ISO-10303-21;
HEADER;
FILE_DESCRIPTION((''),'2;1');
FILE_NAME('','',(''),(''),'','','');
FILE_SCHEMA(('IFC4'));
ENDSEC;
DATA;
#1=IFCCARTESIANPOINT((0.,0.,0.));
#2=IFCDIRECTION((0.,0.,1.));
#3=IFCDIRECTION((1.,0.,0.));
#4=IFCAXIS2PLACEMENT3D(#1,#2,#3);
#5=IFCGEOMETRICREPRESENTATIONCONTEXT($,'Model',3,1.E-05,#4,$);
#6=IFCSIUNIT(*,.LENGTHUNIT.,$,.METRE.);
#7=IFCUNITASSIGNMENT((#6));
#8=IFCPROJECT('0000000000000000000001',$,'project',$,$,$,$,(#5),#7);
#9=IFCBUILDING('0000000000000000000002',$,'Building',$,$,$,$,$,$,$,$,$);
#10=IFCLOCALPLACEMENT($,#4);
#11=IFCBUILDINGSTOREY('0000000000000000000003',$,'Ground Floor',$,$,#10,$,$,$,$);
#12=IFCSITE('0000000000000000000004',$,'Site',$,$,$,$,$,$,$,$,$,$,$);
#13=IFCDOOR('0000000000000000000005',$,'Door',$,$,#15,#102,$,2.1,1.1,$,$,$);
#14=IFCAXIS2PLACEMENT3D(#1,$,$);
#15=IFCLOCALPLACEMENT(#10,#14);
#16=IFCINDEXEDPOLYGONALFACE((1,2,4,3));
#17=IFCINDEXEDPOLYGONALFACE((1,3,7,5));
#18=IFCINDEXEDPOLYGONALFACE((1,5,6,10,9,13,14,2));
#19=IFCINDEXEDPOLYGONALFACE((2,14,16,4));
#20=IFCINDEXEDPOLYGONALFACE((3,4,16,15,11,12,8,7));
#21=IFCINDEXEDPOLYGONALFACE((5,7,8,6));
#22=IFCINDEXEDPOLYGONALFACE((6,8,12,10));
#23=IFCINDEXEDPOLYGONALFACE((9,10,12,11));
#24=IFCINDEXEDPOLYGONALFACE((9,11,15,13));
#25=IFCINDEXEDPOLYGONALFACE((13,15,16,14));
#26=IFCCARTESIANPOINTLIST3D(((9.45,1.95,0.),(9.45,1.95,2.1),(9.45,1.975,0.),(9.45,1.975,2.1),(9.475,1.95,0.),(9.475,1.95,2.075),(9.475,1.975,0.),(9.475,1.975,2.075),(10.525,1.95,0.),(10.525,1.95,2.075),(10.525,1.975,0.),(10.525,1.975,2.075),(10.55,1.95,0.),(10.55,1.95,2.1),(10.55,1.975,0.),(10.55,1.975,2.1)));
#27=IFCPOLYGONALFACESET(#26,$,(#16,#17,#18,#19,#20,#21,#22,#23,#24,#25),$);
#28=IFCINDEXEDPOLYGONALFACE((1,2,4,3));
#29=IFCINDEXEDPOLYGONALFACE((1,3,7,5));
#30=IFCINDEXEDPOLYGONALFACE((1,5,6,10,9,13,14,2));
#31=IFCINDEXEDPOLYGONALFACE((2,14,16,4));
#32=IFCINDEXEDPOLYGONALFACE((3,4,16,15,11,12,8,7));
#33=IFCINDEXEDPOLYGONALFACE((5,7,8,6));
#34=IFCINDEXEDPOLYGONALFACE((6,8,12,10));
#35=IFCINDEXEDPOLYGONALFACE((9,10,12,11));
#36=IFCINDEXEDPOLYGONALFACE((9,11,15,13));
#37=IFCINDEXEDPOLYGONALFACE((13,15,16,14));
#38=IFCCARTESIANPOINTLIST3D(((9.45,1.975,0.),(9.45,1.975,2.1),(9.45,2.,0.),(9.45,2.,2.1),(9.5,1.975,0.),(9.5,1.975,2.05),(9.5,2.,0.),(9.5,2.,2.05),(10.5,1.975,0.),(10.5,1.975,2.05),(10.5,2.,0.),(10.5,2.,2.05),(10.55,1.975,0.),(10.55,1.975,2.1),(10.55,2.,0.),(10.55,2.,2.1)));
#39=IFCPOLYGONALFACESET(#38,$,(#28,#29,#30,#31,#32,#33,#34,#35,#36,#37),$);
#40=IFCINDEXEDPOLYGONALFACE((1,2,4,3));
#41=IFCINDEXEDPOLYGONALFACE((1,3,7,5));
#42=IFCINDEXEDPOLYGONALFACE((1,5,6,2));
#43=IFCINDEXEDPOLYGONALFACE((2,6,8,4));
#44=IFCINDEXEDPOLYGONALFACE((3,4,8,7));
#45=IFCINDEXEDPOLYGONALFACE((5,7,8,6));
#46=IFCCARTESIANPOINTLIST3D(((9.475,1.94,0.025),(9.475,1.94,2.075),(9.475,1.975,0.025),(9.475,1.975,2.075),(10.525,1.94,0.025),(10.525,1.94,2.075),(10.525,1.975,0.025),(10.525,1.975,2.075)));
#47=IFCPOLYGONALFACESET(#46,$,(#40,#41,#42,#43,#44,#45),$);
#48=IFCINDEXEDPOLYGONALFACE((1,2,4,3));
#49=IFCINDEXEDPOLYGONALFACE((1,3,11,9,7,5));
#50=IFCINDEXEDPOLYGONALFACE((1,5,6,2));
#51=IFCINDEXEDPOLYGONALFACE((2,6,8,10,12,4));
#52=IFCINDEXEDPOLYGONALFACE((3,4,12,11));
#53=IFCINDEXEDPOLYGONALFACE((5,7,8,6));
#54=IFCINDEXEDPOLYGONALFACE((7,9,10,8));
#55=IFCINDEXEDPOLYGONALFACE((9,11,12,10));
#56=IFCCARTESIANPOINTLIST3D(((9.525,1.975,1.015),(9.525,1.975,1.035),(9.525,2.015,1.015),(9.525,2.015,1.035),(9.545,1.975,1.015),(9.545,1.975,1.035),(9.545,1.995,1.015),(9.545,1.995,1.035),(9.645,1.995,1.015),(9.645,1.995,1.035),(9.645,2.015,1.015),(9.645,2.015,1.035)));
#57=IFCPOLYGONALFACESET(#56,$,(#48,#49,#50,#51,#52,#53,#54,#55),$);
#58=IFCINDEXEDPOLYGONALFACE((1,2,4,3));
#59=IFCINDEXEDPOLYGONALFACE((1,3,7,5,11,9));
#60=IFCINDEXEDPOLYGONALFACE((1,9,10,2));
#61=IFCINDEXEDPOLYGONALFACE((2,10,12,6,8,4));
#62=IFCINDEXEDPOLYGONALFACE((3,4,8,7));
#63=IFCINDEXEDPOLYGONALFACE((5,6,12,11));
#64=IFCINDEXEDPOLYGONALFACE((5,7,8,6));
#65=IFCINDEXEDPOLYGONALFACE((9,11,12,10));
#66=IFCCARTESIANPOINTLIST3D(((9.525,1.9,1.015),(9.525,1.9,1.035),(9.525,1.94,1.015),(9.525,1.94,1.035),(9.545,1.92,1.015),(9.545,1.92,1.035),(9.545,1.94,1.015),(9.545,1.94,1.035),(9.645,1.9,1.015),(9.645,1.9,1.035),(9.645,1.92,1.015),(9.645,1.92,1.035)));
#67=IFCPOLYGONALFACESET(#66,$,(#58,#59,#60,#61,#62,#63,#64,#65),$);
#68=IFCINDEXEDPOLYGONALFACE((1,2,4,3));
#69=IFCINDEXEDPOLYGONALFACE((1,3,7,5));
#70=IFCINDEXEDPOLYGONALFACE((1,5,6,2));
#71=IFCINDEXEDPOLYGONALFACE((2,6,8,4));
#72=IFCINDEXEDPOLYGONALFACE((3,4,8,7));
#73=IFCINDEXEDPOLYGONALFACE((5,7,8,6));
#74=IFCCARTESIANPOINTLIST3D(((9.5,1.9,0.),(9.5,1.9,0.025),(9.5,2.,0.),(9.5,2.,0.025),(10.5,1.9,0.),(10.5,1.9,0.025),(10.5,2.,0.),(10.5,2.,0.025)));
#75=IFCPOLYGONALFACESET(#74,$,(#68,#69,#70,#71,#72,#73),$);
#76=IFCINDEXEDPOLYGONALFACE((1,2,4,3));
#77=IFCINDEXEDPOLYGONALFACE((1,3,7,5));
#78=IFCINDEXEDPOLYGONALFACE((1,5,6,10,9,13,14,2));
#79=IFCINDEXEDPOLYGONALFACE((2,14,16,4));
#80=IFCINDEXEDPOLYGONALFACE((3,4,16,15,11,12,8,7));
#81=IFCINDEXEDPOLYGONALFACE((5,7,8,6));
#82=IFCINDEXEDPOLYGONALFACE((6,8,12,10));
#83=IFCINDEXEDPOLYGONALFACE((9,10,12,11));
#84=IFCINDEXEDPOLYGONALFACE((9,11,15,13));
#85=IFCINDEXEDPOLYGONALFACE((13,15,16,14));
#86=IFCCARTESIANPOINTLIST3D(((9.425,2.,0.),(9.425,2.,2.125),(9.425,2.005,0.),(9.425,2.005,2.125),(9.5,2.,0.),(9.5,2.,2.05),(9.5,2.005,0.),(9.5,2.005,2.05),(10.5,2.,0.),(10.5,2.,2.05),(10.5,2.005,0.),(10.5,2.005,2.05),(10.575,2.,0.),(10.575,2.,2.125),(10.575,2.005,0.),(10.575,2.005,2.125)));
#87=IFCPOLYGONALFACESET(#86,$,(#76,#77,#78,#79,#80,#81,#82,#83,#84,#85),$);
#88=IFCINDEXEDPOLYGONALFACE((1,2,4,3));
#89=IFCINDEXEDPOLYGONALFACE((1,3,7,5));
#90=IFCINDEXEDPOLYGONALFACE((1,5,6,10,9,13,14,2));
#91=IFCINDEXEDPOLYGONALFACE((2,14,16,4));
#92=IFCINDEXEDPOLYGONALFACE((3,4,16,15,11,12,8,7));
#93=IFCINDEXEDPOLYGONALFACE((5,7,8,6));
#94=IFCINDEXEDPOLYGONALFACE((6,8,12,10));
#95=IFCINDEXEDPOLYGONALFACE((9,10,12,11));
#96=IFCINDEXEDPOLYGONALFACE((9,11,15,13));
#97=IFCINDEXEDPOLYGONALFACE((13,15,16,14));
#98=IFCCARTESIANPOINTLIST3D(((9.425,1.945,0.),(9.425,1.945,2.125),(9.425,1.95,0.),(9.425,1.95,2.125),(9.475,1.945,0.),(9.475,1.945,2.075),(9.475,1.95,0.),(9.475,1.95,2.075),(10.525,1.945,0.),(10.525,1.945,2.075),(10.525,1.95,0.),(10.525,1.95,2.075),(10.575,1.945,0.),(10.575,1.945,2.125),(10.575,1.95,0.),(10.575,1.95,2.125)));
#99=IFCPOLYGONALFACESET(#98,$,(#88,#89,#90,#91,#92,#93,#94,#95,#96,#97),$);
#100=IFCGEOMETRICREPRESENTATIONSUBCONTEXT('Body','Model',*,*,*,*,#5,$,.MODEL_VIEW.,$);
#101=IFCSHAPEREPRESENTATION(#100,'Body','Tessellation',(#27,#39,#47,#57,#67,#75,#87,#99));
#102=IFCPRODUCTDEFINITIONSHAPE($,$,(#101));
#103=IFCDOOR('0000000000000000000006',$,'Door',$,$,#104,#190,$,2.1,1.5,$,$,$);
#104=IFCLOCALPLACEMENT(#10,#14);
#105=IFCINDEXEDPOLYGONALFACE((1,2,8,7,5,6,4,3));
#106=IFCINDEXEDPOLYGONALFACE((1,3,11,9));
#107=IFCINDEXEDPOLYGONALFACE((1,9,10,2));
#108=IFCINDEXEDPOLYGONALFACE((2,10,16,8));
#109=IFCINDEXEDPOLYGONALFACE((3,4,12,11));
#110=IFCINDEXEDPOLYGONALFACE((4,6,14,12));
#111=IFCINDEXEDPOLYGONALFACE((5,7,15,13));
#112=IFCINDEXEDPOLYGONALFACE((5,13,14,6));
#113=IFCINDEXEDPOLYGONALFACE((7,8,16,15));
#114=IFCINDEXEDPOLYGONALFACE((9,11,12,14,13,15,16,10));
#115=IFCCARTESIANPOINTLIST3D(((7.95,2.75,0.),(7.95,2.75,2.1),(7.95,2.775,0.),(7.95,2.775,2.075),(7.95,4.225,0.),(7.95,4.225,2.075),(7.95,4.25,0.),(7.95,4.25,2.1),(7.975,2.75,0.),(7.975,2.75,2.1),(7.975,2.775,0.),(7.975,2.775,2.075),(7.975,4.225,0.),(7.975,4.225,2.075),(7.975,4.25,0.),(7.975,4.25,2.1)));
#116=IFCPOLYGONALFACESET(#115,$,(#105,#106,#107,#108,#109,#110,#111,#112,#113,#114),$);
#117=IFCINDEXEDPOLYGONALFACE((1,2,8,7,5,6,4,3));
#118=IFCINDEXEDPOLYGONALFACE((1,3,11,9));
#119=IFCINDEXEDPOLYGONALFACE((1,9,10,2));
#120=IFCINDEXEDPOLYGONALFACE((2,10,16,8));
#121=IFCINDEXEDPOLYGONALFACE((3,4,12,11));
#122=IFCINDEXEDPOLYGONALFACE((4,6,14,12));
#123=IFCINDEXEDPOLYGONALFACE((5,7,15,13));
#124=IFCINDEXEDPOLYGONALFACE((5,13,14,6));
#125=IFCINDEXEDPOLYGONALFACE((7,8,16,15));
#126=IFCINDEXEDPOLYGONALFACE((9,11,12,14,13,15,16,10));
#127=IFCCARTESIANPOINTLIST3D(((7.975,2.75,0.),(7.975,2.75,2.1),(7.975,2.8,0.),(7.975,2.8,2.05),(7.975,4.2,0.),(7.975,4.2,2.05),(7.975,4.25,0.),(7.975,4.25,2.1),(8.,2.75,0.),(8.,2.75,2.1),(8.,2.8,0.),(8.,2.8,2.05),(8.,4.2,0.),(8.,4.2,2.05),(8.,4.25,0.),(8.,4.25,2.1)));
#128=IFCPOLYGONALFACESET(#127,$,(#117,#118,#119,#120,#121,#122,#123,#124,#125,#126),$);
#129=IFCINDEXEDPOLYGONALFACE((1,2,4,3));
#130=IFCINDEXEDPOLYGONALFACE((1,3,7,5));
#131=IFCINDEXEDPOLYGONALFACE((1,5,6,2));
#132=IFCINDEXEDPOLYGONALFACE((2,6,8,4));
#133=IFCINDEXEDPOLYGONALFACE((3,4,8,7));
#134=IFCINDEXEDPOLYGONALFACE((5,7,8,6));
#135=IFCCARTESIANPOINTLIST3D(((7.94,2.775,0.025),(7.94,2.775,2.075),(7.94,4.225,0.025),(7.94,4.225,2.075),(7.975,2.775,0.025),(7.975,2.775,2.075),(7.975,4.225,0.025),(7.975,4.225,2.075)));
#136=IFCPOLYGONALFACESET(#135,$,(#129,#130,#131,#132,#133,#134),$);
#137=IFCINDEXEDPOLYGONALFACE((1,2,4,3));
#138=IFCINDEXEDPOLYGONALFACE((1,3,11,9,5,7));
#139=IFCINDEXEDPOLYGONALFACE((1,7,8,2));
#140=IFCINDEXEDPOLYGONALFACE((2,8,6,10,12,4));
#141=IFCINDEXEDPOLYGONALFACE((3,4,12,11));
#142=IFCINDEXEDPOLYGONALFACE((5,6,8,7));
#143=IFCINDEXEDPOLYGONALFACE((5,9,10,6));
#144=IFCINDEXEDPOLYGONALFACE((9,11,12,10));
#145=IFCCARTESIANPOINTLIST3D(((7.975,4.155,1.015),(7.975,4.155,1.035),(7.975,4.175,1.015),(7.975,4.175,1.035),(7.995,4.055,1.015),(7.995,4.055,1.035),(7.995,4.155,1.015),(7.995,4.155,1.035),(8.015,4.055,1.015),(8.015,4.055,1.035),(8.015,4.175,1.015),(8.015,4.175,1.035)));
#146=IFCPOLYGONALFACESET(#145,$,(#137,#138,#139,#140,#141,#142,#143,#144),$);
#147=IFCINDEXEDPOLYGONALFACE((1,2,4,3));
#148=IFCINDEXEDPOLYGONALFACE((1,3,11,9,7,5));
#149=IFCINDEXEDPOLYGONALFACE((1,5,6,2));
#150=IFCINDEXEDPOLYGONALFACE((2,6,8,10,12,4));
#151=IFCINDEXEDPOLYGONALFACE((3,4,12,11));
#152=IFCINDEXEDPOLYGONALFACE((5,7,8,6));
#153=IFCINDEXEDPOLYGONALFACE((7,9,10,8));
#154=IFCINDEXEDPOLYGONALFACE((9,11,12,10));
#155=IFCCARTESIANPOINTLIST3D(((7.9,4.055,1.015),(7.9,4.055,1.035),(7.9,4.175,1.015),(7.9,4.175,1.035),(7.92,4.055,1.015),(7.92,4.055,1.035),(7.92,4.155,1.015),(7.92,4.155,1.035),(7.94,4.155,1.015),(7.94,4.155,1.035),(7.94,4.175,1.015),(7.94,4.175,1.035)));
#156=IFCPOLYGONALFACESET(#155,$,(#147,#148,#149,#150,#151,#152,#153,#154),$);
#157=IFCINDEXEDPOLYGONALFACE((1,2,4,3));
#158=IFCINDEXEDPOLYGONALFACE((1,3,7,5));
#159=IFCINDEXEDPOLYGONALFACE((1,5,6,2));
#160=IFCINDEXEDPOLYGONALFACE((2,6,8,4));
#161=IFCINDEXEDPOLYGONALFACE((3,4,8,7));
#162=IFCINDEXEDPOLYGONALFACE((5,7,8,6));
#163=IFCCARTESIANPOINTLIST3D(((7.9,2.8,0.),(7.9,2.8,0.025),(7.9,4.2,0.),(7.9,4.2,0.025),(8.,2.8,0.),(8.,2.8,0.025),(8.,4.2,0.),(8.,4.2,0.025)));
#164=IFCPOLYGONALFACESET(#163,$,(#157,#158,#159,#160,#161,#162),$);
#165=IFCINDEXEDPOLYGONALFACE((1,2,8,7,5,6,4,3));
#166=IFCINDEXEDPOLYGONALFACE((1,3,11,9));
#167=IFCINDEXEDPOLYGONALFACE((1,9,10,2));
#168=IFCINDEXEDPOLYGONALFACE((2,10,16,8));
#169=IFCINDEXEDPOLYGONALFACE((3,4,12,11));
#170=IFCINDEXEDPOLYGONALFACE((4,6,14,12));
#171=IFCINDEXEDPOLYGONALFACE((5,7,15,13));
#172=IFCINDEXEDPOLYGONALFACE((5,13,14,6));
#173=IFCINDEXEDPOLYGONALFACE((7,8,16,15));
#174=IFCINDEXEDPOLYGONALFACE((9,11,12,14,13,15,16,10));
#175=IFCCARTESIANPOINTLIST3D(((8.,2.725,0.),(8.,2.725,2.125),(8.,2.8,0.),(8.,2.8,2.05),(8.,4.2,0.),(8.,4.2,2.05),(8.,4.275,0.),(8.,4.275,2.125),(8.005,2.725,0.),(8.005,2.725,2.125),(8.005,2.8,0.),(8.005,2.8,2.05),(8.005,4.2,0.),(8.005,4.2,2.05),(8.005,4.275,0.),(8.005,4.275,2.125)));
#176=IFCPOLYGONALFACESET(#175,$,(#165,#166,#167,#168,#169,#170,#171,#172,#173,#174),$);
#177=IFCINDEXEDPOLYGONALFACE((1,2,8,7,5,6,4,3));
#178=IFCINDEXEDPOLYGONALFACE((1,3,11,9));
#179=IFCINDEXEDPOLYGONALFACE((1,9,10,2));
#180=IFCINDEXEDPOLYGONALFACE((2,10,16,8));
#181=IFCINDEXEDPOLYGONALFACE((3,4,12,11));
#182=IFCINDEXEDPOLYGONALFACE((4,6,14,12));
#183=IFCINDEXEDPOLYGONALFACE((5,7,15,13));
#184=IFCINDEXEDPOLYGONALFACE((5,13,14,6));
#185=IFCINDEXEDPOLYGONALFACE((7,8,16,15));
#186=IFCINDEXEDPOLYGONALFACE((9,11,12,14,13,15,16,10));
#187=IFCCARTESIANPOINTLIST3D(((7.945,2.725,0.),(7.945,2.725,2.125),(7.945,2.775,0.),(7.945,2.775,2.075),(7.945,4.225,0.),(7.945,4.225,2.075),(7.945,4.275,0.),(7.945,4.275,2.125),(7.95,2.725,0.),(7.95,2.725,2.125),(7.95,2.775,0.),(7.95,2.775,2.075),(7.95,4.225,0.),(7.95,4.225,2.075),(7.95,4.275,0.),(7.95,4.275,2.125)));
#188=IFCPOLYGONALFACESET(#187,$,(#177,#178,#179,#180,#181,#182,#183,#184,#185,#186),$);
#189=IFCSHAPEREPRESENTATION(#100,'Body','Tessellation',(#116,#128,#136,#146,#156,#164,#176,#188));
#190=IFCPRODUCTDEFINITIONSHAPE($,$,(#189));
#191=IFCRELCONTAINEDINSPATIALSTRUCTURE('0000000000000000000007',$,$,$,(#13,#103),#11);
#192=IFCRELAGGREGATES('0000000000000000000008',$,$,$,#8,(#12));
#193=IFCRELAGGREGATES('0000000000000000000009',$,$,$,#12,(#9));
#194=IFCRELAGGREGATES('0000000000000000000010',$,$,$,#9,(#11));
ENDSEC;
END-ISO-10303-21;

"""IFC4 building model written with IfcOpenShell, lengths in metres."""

from ifc_helpers import new_model, si_unit, frame, origin_with_axes, place, context, subcontext, project, spatial, line, indexed_curve, outline, extrude, element, save


model = new_model("IFC4")

# Units and contexts
model_context = context("Model", 3, precision=1e-05, world=origin_with_axes())
body_context = subcontext(model_context, "Body", "Model", "MODEL_VIEW")
ifc_project = project(units=[si_unit("LENGTHUNIT", "METRE")], contexts=[model_context])

# Site, building, storey
site = spatial("IfcSite", under=ifc_project, Name="Site")
building = spatial("IfcBuilding", under=site, Name="Building")
storey_placement = place(None, origin_with_axes())
storey = spatial("IfcBuildingStorey", under=building, at=storey_placement, Name="Ground Floor")

# Doors
door_1_placement = place(storey_placement, frame((10.55, 2.0, 0.0), z_axis=(0.0, 0.0, 1.0), x_axis=(-1.0, 0.0, 0.0)))
element("IfcDoor", 1, at=door_1_placement, inside=storey, Name="Door", OverallHeight=2.1, OverallWidth=1.1, context=body_context, shape_type="SweptSolid", body=[
    extrude(outline(indexed_curve([(0.0, 0.0), (0.0, 2.1), (1.1, 2.1), (1.1, 0.0), (1.075, 0.0), (1.075, 2.075), (0.025, 2.075), (0.025, 0.0)], segments=[line(1, 2, 3, 4, 5, 6, 7, 8, 1)])), frame((0.0, 0.025, 0.0), z_axis=(0.0, -1.0, 0.0), x_axis=(1.0, 0.0, 0.0)), (0.0, 0.0, -1.0), 0.025),
    extrude(outline(indexed_curve([(0.0, 0.0), (0.0, 2.1), (1.1, 2.1), (1.1, 0.0), (1.05, 0.0), (1.05, 2.05), (0.05, 2.05), (0.05, 0.0)], segments=[line(1, 2, 3, 4, 5, 6, 7, 8, 1)])), frame((0.0, 0.0, 0.0), z_axis=(0.0, -1.0, 0.0), x_axis=(1.0, 0.0, 0.0)), (0.0, 0.0, -1.0), 0.025),
    extrude(outline(indexed_curve([(0.0, 0.0), (1.05, 0.0), (1.05, 0.035), (0.0, 0.035)], segments=[line(1, 2, 3, 4, 1)])), frame((0.025, 0.025, 0.025), z_axis=(0.0, 0.0, 1.0), x_axis=(1.0, 0.0, 0.0)), (0.0, 0.0, 1.0), 2.05),
    extrude(outline(indexed_curve([(0.0, 0.0), (0.0, -0.04), (-0.12, -0.04), (-0.12, -0.02), (-0.02, -0.02), (-0.02, 0.0)], segments=[line(1, 2, 3, 4, 5, 6, 1)])), frame((1.025, 0.025, 1.015), z_axis=(0.0, 0.0, 1.0), x_axis=(1.0, 0.0, 0.0)), (0.0, 0.0, 1.0), 0.02),
    extrude(outline(indexed_curve([(0.0, 0.0), (0.0, 0.04), (-0.12, 0.04), (-0.12, 0.02), (-0.02, 0.02), (-0.02, 0.0)], segments=[line(1, 2, 3, 4, 5, 6, 1)])), frame((1.025, 0.06, 1.015), z_axis=(0.0, 0.0, 1.0), x_axis=(1.0, 0.0, 0.0)), (0.0, 0.0, 1.0), 0.02),
    extrude(outline(indexed_curve([(0.0, 0.0), (1.0, 0.0), (1.0, 0.1), (0.0, 0.1)], segments=[line(1, 2, 3, 4, 1)])), frame((0.05, 0.0, 0.0), z_axis=(0.0, 0.0, 1.0), x_axis=(1.0, 0.0, 0.0)), (0.0, 0.0, 1.0), 0.025),
    extrude(outline(indexed_curve([(0.0, 0.0), (0.0, 2.125), (1.15, 2.125), (1.15, 0.0), (1.075, 0.0), (1.075, 2.05), (0.075, 2.05), (0.075, 0.0)], segments=[line(1, 2, 3, 4, 5, 6, 7, 8, 1)])), frame((-0.025, -0.005, 0.0), z_axis=(0.0, -1.0, 0.0), x_axis=(1.0, 0.0, 0.0)), (0.0, 0.0, -1.0), 0.005),
    extrude(outline(indexed_curve([(0.0, 0.0), (0.0, 2.125), (1.15, 2.125), (1.15, 0.0), (1.1, 0.0), (1.1, 2.075), (0.05, 2.075), (0.05, 0.0)], segments=[line(1, 2, 3, 4, 5, 6, 7, 8, 1)])), frame((-0.025, 0.05, 0.0), z_axis=(0.0, -1.0, 0.0), x_axis=(1.0, 0.0, 0.0)), (0.0, 0.0, -1.0), 0.005),
])
door_2_placement = place(storey_placement, frame((8.0, 2.75, 0.0), z_axis=(0.0, 0.0, 1.0), x_axis=(0.0, 1.0, 0.0)))
element("IfcDoor", 2, at=door_2_placement, inside=storey, Name="Door", OverallHeight=2.1, OverallWidth=1.5, context=body_context, shape_type="SweptSolid", body=[
    extrude(outline(indexed_curve([(0.0, 0.0), (0.0, 2.1), (1.5, 2.1), (1.5, 0.0), (1.475, 0.0), (1.475, 2.075), (0.025, 2.075), (0.025, 0.0)], segments=[line(1, 2, 3, 4, 5, 6, 7, 8, 1)])), frame((0.0, 0.025, 0.0), z_axis=(0.0, -1.0, 0.0), x_axis=(1.0, 0.0, 0.0)), (0.0, 0.0, -1.0), 0.025),
    extrude(outline(indexed_curve([(0.0, 0.0), (0.0, 2.1), (1.5, 2.1), (1.5, 0.0), (1.45, 0.0), (1.45, 2.05), (0.05, 2.05), (0.05, 0.0)], segments=[line(1, 2, 3, 4, 5, 6, 7, 8, 1)])), frame((0.0, 0.0, 0.0), z_axis=(0.0, -1.0, 0.0), x_axis=(1.0, 0.0, 0.0)), (0.0, 0.0, -1.0), 0.025),
    extrude(outline(indexed_curve([(0.0, 0.0), (1.45, 0.0), (1.45, 0.035), (0.0, 0.035)], segments=[line(1, 2, 3, 4, 1)])), frame((0.025, 0.025, 0.025), z_axis=(0.0, 0.0, 1.0), x_axis=(1.0, 0.0, 0.0)), (0.0, 0.0, 1.0), 2.05),
    extrude(outline(indexed_curve([(0.0, 0.0), (0.0, -0.04), (-0.12, -0.04), (-0.12, -0.02), (-0.02, -0.02), (-0.02, 0.0)], segments=[line(1, 2, 3, 4, 5, 6, 1)])), frame((1.425, 0.025, 1.015), z_axis=(0.0, 0.0, 1.0), x_axis=(1.0, 0.0, 0.0)), (0.0, 0.0, 1.0), 0.02),
    extrude(outline(indexed_curve([(0.0, 0.0), (0.0, 0.04), (-0.12, 0.04), (-0.12, 0.02), (-0.02, 0.02), (-0.02, 0.0)], segments=[line(1, 2, 3, 4, 5, 6, 1)])), frame((1.425, 0.06, 1.015), z_axis=(0.0, 0.0, 1.0), x_axis=(1.0, 0.0, 0.0)), (0.0, 0.0, 1.0), 0.02),
    extrude(outline(indexed_curve([(0.0, 0.0), (1.4, 0.0), (1.4, 0.1), (0.0, 0.1)], segments=[line(1, 2, 3, 4, 1)])), frame((0.05, 0.0, 0.0), z_axis=(0.0, 0.0, 1.0), x_axis=(1.0, 0.0, 0.0)), (0.0, 0.0, 1.0), 0.025),
    extrude(outline(indexed_curve([(0.0, 0.0), (0.0, 2.125), (1.55, 2.125), (1.55, 0.0), (1.475, 0.0), (1.475, 2.05), (0.075, 2.05), (0.075, 0.0)], segments=[line(1, 2, 3, 4, 5, 6, 7, 8, 1)])), frame((-0.025, -0.005, 0.0), z_axis=(0.0, -1.0, 0.0), x_axis=(1.0, 0.0, 0.0)), (0.0, 0.0, -1.0), 0.005),
    extrude(outline(indexed_curve([(0.0, 0.0), (0.0, 2.125), (1.55, 2.125), (1.55, 0.0), (1.5, 0.0), (1.5, 2.075), (0.05, 2.075), (0.05, 0.0)], segments=[line(1, 2, 3, 4, 5, 6, 7, 8, 1)])), frame((-0.025, 0.05, 0.0), z_axis=(0.0, -1.0, 0.0), x_axis=(1.0, 0.0, 0.0)), (0.0, 0.0, -1.0), 0.005),
])

save(model, "model.ifc")
